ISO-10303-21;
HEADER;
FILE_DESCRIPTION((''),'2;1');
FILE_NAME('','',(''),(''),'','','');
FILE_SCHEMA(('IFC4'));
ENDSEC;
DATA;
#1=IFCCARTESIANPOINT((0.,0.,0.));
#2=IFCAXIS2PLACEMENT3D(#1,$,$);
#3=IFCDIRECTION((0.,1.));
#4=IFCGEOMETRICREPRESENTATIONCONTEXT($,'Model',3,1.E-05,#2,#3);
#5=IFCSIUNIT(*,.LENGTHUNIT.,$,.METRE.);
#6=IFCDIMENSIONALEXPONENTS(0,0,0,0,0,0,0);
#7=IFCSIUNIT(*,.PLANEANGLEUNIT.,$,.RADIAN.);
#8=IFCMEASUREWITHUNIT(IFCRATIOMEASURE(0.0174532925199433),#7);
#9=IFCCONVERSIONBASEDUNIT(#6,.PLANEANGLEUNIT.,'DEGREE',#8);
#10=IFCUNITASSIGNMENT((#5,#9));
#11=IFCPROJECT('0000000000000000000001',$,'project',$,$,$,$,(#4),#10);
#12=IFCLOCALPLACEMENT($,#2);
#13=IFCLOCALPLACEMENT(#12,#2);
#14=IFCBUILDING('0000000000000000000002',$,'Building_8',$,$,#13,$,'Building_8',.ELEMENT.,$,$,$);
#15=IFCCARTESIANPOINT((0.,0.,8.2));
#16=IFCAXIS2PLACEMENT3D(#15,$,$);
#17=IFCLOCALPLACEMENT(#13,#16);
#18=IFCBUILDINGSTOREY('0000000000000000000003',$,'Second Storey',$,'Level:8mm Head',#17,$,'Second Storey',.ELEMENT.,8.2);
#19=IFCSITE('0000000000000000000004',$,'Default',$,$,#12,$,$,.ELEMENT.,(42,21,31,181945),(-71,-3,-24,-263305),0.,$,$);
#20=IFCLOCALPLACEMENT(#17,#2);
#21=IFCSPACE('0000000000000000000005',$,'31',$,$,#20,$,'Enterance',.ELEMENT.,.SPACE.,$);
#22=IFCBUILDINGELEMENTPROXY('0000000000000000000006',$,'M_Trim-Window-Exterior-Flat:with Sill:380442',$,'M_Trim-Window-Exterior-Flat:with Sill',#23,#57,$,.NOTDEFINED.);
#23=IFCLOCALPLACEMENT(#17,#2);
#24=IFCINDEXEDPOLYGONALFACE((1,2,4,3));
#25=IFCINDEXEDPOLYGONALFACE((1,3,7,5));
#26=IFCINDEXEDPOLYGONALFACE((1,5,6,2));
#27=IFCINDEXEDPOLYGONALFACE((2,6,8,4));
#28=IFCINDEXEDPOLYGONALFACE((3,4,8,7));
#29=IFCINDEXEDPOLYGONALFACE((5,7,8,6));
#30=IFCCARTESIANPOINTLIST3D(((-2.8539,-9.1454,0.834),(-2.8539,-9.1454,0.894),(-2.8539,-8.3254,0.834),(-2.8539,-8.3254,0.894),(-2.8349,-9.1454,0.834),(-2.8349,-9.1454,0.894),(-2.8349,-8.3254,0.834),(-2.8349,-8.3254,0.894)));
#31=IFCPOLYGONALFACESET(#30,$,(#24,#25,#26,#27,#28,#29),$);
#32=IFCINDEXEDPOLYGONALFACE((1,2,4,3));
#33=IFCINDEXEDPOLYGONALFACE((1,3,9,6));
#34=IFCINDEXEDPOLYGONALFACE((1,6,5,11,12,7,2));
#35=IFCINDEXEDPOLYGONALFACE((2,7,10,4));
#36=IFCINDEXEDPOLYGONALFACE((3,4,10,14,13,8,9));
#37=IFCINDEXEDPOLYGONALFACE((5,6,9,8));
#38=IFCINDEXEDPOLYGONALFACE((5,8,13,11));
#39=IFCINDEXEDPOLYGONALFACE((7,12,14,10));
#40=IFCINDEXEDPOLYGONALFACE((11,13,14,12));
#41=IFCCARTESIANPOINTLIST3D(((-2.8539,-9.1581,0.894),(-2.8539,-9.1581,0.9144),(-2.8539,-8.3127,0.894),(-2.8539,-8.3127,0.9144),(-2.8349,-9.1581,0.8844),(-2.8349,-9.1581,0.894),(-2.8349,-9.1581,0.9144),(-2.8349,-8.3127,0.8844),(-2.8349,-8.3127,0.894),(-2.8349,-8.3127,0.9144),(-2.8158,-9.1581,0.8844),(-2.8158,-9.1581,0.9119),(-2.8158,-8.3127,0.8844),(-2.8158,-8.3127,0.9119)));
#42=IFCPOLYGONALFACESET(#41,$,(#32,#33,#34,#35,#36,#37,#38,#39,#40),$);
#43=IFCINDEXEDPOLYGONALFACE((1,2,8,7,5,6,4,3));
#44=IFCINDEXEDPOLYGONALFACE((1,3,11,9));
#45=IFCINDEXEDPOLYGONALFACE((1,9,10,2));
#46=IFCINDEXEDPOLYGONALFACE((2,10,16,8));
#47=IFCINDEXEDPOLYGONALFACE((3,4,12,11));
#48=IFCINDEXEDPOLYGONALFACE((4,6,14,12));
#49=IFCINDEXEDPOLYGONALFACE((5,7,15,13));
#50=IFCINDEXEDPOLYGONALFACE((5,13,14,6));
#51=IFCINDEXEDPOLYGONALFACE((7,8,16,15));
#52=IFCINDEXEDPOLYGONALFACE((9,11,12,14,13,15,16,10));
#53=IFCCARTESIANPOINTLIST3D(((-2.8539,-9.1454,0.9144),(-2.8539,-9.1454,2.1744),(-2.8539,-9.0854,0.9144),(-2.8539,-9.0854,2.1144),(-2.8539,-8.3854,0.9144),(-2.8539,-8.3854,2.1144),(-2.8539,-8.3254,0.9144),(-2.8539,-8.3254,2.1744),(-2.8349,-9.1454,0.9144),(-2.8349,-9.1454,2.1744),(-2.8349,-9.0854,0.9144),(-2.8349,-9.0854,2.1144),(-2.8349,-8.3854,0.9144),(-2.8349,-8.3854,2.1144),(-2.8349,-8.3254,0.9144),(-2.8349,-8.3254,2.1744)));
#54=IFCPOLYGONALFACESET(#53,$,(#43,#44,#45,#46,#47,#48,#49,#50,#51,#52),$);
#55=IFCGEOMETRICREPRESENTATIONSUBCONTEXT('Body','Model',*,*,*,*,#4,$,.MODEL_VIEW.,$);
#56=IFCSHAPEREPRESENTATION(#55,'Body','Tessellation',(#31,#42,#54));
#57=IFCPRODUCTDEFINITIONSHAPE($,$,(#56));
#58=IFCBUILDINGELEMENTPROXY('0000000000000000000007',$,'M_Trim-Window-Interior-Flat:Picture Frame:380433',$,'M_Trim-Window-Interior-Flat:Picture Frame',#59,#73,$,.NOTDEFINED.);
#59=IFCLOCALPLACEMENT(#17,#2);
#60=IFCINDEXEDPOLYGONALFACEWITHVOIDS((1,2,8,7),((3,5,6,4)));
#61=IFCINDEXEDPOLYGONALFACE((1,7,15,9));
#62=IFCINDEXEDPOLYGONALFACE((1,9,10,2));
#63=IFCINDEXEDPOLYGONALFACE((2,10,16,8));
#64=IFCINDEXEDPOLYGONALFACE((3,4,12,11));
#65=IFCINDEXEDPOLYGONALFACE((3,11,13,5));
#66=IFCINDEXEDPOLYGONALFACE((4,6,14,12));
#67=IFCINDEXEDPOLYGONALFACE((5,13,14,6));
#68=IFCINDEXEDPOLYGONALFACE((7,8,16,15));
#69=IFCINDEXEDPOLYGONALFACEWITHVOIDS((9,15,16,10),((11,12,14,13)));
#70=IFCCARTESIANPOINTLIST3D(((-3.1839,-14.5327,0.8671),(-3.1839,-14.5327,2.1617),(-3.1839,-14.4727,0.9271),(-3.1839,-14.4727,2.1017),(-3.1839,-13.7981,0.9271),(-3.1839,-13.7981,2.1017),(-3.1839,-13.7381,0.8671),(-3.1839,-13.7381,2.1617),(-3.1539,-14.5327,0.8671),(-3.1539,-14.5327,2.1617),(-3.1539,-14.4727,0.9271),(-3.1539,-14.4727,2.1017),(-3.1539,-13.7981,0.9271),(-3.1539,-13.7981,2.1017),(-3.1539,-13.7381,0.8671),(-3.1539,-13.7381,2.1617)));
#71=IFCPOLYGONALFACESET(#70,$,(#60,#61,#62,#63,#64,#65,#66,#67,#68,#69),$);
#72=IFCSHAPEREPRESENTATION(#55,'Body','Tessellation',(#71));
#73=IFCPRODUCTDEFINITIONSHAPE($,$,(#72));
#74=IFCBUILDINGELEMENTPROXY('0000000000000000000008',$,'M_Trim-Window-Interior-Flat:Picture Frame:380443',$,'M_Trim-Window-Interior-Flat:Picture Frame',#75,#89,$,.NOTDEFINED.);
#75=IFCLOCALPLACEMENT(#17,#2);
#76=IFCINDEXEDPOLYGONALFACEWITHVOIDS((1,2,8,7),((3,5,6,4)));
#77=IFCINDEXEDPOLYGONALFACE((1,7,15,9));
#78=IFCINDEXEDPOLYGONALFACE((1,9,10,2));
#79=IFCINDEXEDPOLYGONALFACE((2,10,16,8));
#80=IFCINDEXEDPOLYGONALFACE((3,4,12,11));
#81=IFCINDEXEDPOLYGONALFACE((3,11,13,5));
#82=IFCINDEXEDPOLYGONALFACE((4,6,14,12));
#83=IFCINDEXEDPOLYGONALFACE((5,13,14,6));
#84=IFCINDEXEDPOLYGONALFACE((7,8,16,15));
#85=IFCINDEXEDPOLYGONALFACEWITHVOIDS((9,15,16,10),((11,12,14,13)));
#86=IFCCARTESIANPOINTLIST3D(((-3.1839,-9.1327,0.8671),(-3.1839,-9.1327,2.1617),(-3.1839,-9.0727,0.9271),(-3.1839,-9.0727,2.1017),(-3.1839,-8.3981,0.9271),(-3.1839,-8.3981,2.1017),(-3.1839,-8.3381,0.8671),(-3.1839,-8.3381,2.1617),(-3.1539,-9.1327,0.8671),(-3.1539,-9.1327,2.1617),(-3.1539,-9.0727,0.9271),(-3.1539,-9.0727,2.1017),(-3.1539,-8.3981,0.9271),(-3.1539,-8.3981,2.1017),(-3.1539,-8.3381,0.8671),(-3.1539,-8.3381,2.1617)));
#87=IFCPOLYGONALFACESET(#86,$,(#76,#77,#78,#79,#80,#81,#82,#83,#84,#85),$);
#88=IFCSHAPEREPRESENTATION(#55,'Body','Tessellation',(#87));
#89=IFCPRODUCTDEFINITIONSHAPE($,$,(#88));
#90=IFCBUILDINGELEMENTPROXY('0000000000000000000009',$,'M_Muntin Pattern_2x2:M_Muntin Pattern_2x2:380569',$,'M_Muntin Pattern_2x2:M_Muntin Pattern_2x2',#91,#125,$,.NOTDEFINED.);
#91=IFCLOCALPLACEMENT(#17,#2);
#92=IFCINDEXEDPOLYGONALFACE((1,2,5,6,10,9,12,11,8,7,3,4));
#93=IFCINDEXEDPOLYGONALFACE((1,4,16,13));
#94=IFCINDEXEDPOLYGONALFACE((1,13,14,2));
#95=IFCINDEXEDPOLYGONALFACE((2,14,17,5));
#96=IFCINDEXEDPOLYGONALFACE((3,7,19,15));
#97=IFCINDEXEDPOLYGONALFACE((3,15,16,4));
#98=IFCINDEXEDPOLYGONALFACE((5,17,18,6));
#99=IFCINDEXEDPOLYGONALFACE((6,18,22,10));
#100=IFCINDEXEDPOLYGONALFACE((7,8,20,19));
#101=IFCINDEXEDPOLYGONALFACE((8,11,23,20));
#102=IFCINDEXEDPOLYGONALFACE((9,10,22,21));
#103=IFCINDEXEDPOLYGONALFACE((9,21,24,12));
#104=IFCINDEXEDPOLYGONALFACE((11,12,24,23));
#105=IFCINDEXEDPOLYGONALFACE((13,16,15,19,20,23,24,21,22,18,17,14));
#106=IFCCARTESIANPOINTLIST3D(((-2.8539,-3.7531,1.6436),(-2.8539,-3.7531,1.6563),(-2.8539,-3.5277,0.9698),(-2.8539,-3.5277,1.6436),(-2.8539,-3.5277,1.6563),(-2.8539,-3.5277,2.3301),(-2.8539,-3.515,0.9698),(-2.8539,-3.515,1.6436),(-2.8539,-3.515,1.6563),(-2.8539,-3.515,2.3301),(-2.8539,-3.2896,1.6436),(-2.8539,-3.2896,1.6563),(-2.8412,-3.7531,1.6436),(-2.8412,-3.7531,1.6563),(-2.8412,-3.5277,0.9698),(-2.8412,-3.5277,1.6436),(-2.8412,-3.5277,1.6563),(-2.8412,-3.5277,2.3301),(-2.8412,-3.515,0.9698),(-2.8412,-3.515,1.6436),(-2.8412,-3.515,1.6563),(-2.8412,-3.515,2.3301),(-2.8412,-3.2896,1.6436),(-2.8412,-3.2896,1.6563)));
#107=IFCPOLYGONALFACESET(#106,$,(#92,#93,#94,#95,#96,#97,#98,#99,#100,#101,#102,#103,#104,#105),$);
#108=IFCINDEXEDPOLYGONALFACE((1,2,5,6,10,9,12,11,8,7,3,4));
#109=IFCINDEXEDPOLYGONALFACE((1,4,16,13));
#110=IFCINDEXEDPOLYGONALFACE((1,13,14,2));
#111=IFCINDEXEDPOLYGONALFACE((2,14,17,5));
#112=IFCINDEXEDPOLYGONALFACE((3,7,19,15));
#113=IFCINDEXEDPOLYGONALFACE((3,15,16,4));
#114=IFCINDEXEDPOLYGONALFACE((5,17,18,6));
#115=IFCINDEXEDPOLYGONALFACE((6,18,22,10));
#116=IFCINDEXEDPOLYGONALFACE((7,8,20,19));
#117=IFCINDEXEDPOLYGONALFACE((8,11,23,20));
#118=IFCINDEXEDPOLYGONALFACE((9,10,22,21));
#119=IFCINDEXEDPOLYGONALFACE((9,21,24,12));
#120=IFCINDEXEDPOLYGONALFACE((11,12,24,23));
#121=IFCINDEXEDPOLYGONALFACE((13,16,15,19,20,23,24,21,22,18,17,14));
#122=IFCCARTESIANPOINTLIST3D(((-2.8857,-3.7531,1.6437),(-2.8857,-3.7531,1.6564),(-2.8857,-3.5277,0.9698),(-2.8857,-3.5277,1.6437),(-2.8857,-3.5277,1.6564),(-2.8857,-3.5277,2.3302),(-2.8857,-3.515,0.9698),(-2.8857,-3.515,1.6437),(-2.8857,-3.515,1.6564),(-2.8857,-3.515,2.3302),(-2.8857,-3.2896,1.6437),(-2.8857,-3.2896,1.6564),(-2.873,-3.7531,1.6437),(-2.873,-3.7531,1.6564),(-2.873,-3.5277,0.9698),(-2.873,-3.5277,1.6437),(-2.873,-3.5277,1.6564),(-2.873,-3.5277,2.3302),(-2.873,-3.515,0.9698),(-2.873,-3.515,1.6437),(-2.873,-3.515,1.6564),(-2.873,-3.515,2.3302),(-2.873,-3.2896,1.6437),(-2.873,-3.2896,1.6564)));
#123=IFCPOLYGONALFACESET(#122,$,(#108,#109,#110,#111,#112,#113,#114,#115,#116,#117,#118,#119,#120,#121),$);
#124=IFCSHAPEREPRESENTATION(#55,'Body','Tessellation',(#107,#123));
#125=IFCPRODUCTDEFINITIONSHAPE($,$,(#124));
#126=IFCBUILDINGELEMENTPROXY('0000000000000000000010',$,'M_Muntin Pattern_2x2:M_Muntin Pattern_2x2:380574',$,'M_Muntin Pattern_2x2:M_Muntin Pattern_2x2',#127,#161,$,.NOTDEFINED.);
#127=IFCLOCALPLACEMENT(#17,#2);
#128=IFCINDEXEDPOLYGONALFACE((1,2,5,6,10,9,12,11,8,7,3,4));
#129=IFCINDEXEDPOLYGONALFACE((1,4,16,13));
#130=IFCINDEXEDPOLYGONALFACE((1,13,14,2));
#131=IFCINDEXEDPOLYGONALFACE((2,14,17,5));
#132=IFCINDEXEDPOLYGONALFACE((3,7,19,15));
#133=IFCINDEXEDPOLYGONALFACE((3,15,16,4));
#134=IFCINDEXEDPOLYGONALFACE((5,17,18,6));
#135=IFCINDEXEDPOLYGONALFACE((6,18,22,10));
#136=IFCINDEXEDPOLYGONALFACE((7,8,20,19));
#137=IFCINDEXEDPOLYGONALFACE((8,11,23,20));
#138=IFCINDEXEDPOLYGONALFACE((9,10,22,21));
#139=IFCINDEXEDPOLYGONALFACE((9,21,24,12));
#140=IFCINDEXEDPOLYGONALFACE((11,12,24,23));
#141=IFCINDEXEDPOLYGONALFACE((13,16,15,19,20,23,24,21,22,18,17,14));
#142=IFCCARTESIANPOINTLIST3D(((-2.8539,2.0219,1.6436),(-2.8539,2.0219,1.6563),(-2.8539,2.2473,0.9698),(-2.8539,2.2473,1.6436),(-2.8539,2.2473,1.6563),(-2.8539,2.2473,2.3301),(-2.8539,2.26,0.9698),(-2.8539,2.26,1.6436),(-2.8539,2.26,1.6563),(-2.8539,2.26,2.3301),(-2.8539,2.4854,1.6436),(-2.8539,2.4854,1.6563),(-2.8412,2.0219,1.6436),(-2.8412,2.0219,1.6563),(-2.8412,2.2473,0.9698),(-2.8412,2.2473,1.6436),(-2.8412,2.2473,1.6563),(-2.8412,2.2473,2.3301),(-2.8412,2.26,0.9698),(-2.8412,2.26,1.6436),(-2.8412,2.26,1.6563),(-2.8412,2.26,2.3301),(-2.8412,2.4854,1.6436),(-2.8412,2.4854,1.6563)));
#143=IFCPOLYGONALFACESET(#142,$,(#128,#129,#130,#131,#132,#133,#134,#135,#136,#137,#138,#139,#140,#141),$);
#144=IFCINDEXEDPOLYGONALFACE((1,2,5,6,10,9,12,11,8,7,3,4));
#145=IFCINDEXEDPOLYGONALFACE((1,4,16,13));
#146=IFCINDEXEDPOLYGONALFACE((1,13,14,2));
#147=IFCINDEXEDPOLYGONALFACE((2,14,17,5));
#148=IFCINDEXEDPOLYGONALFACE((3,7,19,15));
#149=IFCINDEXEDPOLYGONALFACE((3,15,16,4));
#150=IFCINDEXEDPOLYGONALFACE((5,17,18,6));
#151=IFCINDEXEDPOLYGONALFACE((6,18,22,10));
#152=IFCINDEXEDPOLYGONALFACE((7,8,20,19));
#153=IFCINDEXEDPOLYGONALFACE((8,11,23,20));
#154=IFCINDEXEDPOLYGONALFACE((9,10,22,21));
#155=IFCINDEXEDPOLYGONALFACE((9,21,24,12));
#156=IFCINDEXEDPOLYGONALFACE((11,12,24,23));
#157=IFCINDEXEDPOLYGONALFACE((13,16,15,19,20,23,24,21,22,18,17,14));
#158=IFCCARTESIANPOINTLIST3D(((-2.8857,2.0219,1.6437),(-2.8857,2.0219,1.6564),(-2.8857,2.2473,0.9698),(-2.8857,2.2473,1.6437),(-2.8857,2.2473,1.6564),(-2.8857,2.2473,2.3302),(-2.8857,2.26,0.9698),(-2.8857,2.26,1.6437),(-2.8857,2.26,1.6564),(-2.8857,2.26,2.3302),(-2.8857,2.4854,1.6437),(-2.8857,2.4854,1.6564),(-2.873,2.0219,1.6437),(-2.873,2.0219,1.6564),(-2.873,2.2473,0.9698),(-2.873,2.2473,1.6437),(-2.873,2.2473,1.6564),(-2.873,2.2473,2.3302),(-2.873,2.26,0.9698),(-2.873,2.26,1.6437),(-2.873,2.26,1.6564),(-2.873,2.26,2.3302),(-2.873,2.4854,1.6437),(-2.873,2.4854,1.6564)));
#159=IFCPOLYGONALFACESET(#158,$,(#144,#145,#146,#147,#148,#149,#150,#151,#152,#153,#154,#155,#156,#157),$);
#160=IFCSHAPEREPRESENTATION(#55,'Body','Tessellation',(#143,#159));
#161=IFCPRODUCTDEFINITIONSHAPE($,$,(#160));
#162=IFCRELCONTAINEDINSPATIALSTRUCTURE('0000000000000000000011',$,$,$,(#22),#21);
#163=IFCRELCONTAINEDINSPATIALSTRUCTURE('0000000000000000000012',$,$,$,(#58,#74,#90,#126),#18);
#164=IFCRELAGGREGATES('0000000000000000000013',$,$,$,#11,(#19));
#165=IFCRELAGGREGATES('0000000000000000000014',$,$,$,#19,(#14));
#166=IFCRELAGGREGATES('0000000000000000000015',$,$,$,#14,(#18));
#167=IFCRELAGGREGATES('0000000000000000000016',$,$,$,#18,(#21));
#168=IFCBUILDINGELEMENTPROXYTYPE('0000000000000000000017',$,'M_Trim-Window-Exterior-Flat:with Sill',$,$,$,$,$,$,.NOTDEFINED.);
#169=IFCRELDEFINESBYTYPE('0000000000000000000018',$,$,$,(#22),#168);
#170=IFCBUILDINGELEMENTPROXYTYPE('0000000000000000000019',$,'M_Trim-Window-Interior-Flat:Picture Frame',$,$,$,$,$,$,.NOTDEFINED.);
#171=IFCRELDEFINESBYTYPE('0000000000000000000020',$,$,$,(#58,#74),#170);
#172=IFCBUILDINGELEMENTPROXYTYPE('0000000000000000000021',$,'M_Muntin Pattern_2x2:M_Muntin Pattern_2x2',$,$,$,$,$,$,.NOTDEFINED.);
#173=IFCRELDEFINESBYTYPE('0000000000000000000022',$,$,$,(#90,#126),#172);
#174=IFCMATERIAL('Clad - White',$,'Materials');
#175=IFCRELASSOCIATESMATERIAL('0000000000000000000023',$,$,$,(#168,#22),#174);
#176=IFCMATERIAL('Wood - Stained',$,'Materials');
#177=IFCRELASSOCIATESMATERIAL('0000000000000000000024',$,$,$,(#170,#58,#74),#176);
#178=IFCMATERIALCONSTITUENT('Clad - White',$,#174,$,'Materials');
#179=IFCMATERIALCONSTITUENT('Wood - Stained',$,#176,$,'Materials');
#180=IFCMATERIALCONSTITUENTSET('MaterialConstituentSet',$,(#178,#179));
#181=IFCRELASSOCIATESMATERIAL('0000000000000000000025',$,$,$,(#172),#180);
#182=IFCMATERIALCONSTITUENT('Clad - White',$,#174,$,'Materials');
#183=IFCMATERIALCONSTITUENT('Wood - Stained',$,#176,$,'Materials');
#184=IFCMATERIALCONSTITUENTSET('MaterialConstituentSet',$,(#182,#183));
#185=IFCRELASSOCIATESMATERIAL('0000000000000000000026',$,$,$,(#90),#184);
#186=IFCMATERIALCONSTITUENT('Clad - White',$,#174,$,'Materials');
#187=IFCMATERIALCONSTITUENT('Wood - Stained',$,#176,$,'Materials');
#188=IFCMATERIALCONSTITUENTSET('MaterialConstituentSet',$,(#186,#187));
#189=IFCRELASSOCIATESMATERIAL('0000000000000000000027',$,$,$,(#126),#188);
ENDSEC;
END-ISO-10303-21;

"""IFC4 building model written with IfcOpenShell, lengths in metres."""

from ifc_helpers import new_model, entity, si_unit, converted_unit, direction, frame, origin, place, context, subcontext, project, spatial, indexed_curve, outline, extrude, source, transform, mapped, material, constituent, constituent_set, type_object, type_shapes, element, save


model = new_model("IFC4")

# Units and contexts
model_context = context("Model", 3, precision=1e-05, world=origin(), true_north=direction((0.0, 1.0)))
body_context = subcontext(model_context, "Body", "Model", "MODEL_VIEW")
ifc_project = project(units=[si_unit("LENGTHUNIT", "METRE"), converted_unit("PLANEANGLEUNIT", "DEGREE", entity("IfcRatioMeasure", 0.0174532925199433), si_unit("PLANEANGLEUNIT", "RADIAN"), dimensions=[0, 0, 0, 0, 0, 0, 0])], contexts=[model_context])

# Site, building, storey
site_placement = place(None, origin())
site = spatial("IfcSite", under=ifc_project, at=site_placement, Name="Default", CompositionType="ELEMENT", RefLatitude=(42, 21, 31, 181945), RefLongitude=(-71, -3, -24, -263305), RefElevation=0.0)
building_placement = place(site_placement, origin())
building = spatial("IfcBuilding", under=site, at=building_placement, Name="Building_8", LongName="Building_8", CompositionType="ELEMENT")
storey_placement = place(building_placement, frame((0.0, 0.0, 8.2)))
storey = spatial("IfcBuildingStorey", under=building, at=storey_placement, Name="Second Storey", ObjectType="Level:8mm Head", LongName="Second Storey", CompositionType="ELEMENT", Elevation=8.2)

# Shared definitions
ifc_material_1 = material(Name="Clad - White", Category="Materials")
ifc_material_2 = material(Name="Wood - Stained", Category="Materials")

# Shared definitions
space_1_placement = place(storey_placement, origin())
space_1 = spatial("IfcSpace", under=storey, at=space_1_placement, Name="31", LongName="Enterance", CompositionType="ELEMENT", PredefinedType="SPACE")

# Building element proxies
building_element_proxy_type_1 = type_object("IfcBuildingElementProxyType", Name="M_Trim-Window-Exterior-Flat:with Sill", PredefinedType="NOTDEFINED", material=ifc_material_1)
shared_shape_1 = source(origin(), body_context, "Body", "SweptSolid", [
    extrude(outline(indexed_curve([(-0.41, -0.03), (0.41, -0.03), (0.41, 0.03), (-0.41, 0.03), (-0.41, -0.03)], self_intersect=False)), frame((0.0, -1.2504, 0.0), z_axis=(0.0, 0.0, 1.0), x_axis=(-1.0, 0.0, 0.0)), (0.0, 0.0, 1.0), 0.0191),
    extrude(outline(indexed_curve([(-0.019, -0.0152), (0.0, -0.0152), (0.0, -0.0057), (0.019, -0.0057), (0.019, 0.0148), (0.0, 0.0148), (-0.019, 0.0123), (-0.019, -0.0152)], self_intersect=False)), frame((-0.4227, -1.2148, 0.019), z_axis=(1.0, 0.0, 0.0), x_axis=(0.0, 0.0, -1.0)), (0.0, 0.0, 1.0), 0.8454),
    extrude(outline(indexed_curve([(-0.645, -0.41), (0.615, -0.41), (0.615, -0.35), (-0.585, -0.35), (-0.585, 0.35), (0.615, 0.35), (0.615, 0.41), (-0.645, 0.41), (-0.645, -0.41)], self_intersect=False)), frame((0.0, -0.585, 0.0), z_axis=(0.0, 0.0, 1.0), x_axis=(0.0, -1.0, 0.0)), (0.0, 0.0, 1.0), 0.0191),
])
type_shapes(building_element_proxy_type_1, [shared_shape_1])
for number, where, z_axis, x_axis, name in (
    (1, (-2.8539, -8.7354, 2.1144), (1.0, 0.0, 0.0), (0.0, 1.0, 0.0), "M_Trim-Window-Exterior-Flat:with Sill:380442"),
):
    element("IfcBuildingElementProxy", number, at=place(space_1_placement, frame(where, z_axis=z_axis, x_axis=x_axis)), inside=space_1, type_object=building_element_proxy_type_1, material=ifc_material_1, Name=name, ObjectType="M_Trim-Window-Exterior-Flat:with Sill", PredefinedType="NOTDEFINED", context=body_context, shape_type="MappedRepresentation", body=[
        mapped(shared_shape_1, transform((0.0, 0.0, 0.0), scale=1.0)),
    ])
building_element_proxy_type_2 = type_object("IfcBuildingElementProxyType", Name="M_Trim-Window-Interior-Flat:Picture Frame", PredefinedType="NOTDEFINED", material=ifc_material_2)
shared_shape_2 = source(origin(), body_context, "Body", "SweptSolid", [
    extrude(outline(indexed_curve([(-0.3973, -0.6473), (0.3973, -0.6473), (0.3973, 0.6473), (-0.3973, 0.6473), (-0.3973, -0.6473)], self_intersect=False), holes=[indexed_curve([(-0.3373, -0.5873), (-0.3373, 0.5873), (0.3373, 0.5873), (0.3373, -0.5873), (-0.3373, -0.5873)], self_intersect=False)]), frame((0.0, -0.6, 0.0), z_axis=(0.0, 0.0, 1.0), x_axis=(-1.0, 0.0, 0.0)), (0.0, 0.0, 1.0), 0.03),
])
type_shapes(building_element_proxy_type_2, [shared_shape_2])
for number, where, z_axis, x_axis, name in (
    (2, (-3.1539, -14.1354, 2.1144), (-1.0, 0.0, 0.0), (0.0, -1.0, 0.0), "M_Trim-Window-Interior-Flat:Picture Frame:380433"),
    (3, (-3.1539, -8.7354, 2.1144), (-1.0, 0.0, 0.0), (0.0, -1.0, 0.0), "M_Trim-Window-Interior-Flat:Picture Frame:380443"),
):
    element("IfcBuildingElementProxy", number, at=place(storey_placement, frame(where, z_axis=z_axis, x_axis=x_axis)), inside=storey, type_object=building_element_proxy_type_2, material=ifc_material_2, Name=name, ObjectType="M_Trim-Window-Interior-Flat:Picture Frame", PredefinedType="NOTDEFINED", context=body_context, shape_type="MappedRepresentation", body=[
        mapped(shared_shape_2, transform((0.0, 0.0, 0.0), scale=1.0)),
    ])
ifc_constituent_1 = constituent(ifc_material_1, Name="Clad - White", Category="Materials")
ifc_constituent_2 = constituent(ifc_material_2, Name="Wood - Stained", Category="Materials")
ifc_constituent_set_1 = constituent_set(constituents=[ifc_constituent_1, ifc_constituent_2], Name="MaterialConstituentSet")
ifc_constituent_3 = constituent(ifc_material_1, Name="Clad - White", Category="Materials")
ifc_constituent_4 = constituent(ifc_material_2, Name="Wood - Stained", Category="Materials")
ifc_constituent_set_2 = constituent_set(constituents=[ifc_constituent_3, ifc_constituent_4], Name="MaterialConstituentSet")
building_element_proxy_type_3 = type_object("IfcBuildingElementProxyType", Name="M_Muntin Pattern_2x2:M_Muntin Pattern_2x2", PredefinedType="NOTDEFINED", material=ifc_constituent_set_2)
shared_shape_3 = source(origin(), body_context, "Body", "SweptSolid", [
    extrude(outline(indexed_curve([(0.0064, -0.0064), (0.6801, -0.0064), (0.6801, 0.0063), (0.0064, 0.0063), (0.0064, 0.2317), (-0.0063, 0.2317), (-0.0063, 0.0063), (-0.6802, 0.0063), (-0.6802, -0.0064), (-0.0063, -0.0064), (-0.0063, -0.2317), (0.0064, -0.2317), (0.0064, -0.0064)], self_intersect=False)), frame((0.0, -0.0222, 0.6801), z_axis=(0.0, 1.0, 0.0), x_axis=(0.0, 0.0, 1.0)), (0.0, 0.0, 1.0), 0.0127),
    extrude(outline(indexed_curve([(0.0064, -0.0064), (0.6802, -0.0064), (0.6802, 0.0063), (0.0064, 0.0063), (0.0064, 0.2317), (-0.0063, 0.2317), (-0.0063, 0.0063), (-0.6802, 0.0063), (-0.6802, -0.0064), (-0.0063, -0.0064), (-0.0063, -0.2317), (0.0064, -0.2317), (0.0064, -0.0064)], self_intersect=False)), frame((0.0, 0.0095, 0.6802), z_axis=(0.0, 1.0, 0.0), x_axis=(0.0, 0.0, 1.0)), (0.0, 0.0, 1.0), 0.0127),
])
type_shapes(building_element_proxy_type_3, [shared_shape_3])
proxy_1_placement = place(storey_placement, frame((-2.8634, -3.5213, 0.9698), z_axis=(0.0, 0.0, 1.0), x_axis=(0.0, 1.0, 0.0)))
element("IfcBuildingElementProxy", 4, at=proxy_1_placement, inside=storey, type_object=building_element_proxy_type_3, material=ifc_constituent_set_1, Name="M_Muntin Pattern_2x2:M_Muntin Pattern_2x2:380569", ObjectType="M_Muntin Pattern_2x2:M_Muntin Pattern_2x2", PredefinedType="NOTDEFINED", context=body_context, shape_type="MappedRepresentation", body=[
    mapped(shared_shape_3, transform((0.0, 0.0, 0.0), scale=1.0)),
])
ifc_constituent_5 = constituent(ifc_material_1, Name="Clad - White", Category="Materials")
ifc_constituent_6 = constituent(ifc_material_2, Name="Wood - Stained", Category="Materials")
ifc_constituent_set_3 = constituent_set(constituents=[ifc_constituent_5, ifc_constituent_6], Name="MaterialConstituentSet")
proxy_2_placement = place(storey_placement, frame((-2.8634, 2.2537, 0.9698), z_axis=(0.0, 0.0, 1.0), x_axis=(0.0, 1.0, 0.0)))
element("IfcBuildingElementProxy", 5, at=proxy_2_placement, inside=storey, type_object=building_element_proxy_type_3, material=ifc_constituent_set_3, Name="M_Muntin Pattern_2x2:M_Muntin Pattern_2x2:380574", ObjectType="M_Muntin Pattern_2x2:M_Muntin Pattern_2x2", PredefinedType="NOTDEFINED", context=body_context, shape_type="MappedRepresentation", body=[
    mapped(shared_shape_3, transform((0.0, 0.0, 0.0), scale=1.0)),
])

save(model, "model.ifc")
